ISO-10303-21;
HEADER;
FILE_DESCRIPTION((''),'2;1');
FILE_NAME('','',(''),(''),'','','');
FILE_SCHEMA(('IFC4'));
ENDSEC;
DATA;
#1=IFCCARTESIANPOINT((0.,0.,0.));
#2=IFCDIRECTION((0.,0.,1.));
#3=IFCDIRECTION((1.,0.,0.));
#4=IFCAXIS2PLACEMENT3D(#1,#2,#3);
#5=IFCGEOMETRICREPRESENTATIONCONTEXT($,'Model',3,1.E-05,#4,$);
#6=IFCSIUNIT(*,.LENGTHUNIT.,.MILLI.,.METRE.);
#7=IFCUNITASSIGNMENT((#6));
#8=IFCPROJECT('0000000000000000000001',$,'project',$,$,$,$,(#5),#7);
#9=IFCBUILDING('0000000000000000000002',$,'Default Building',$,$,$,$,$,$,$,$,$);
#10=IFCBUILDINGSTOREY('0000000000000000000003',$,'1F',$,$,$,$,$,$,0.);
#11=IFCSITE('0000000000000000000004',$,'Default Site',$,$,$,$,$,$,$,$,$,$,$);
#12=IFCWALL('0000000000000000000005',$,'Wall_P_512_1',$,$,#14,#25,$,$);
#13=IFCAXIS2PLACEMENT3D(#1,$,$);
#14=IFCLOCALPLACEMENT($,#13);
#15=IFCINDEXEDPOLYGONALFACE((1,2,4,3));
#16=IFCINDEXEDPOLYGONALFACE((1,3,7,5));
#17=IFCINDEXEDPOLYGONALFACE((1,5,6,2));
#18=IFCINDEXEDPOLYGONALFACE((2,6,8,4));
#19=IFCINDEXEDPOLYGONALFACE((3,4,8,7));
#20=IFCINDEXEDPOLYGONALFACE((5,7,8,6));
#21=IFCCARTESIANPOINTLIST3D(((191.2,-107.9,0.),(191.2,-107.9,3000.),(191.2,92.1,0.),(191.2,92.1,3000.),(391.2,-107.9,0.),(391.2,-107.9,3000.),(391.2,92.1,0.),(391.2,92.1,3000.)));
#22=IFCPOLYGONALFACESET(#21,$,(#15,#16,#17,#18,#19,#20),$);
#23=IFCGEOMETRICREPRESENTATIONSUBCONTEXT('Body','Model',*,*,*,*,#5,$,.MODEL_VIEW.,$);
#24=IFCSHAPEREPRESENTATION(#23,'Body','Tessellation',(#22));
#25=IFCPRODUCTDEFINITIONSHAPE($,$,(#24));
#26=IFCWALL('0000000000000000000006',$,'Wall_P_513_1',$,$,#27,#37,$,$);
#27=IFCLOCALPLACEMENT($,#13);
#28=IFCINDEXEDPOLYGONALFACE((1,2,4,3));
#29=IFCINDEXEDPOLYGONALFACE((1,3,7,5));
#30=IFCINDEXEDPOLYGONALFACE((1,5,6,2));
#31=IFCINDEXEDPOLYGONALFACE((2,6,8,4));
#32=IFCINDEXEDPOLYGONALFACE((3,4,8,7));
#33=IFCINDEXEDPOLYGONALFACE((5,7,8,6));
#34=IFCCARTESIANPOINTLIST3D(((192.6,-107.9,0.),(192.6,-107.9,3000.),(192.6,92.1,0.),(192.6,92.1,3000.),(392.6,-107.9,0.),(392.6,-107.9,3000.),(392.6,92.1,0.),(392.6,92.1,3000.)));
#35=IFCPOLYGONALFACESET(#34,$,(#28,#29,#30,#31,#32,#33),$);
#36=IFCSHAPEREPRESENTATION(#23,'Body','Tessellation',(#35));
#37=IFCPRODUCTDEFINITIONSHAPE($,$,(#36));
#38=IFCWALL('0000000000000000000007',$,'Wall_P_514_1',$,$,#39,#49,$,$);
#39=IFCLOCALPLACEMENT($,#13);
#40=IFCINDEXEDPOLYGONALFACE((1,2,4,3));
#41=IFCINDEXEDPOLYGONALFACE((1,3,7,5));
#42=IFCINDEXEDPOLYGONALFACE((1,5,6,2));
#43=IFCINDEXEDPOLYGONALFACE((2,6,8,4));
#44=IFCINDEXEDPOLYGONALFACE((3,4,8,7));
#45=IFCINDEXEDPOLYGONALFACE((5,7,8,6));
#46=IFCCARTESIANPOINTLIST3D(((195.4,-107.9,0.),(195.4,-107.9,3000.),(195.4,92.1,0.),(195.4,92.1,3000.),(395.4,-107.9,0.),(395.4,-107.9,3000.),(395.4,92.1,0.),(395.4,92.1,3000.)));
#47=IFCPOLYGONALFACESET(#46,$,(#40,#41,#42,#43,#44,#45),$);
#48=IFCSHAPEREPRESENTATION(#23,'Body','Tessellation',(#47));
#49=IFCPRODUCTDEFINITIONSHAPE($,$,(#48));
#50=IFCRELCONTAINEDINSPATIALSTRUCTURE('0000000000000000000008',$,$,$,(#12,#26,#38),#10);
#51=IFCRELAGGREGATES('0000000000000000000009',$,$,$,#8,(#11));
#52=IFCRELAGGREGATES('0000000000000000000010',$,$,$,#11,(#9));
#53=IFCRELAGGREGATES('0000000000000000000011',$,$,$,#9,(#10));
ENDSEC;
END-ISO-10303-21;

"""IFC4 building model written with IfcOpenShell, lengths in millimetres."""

from ifc_helpers import new_model, si_unit, frame, origin_with_axes, place, context, subcontext, project, spatial, indexed_curve, outline, extrude, element, save


model = new_model("IFC4")

# Units and contexts
model_context = context("Model", 3, precision=1e-05, world=origin_with_axes())
body_context = subcontext(model_context, "Body", "Model", "MODEL_VIEW")
ifc_project = project(units=[si_unit("LENGTHUNIT", "METRE", prefix="MILLI")], contexts=[model_context])

# Site, building, storey
site = spatial("IfcSite", under=ifc_project, Name="Default Site")
building = spatial("IfcBuilding", under=site, Name="Default Building")
storey = spatial("IfcBuildingStorey", under=building, Name="1F", Elevation=0.0)

# Walls
wall_1_placement = place(None, frame((191.2, 92.1, 0.0), z_axis=(0.0, 0.0, 1.0), x_axis=(0.0, -1.0, 0.0)))
element("IfcWall", 1, at=wall_1_placement, inside=storey, Name="Wall_P_512_1", context=body_context, shape_type="SweptSolid", body=[
    extrude(outline(indexed_curve([(0.0, 0.0), (0.0, 200.0), (200.0, 200.0), (200.0, 0.0), (0.0, 0.0)], self_intersect=False)), origin_with_axes(), (0.0, 0.0, 1.0), 3000.0),
])
wall_2_placement = place(None, frame((192.6, 92.1, 0.0), z_axis=(0.0, 0.0, 1.0), x_axis=(0.0, -1.0, 0.0)))
element("IfcWall", 2, at=wall_2_placement, inside=storey, Name="Wall_P_513_1", context=body_context, shape_type="SweptSolid", body=[
    extrude(outline(indexed_curve([(0.0, 0.0), (0.0, 200.0), (200.0, 200.0), (200.0, 0.0), (0.0, 0.0)], self_intersect=False)), origin_with_axes(), (0.0, 0.0, 1.0), 3000.0),
])
wall_3_placement = place(None, frame((195.4, 92.1, 0.0), z_axis=(0.0, 0.0, 1.0), x_axis=(0.0, -1.0, 0.0)))
element("IfcWall", 3, at=wall_3_placement, inside=storey, Name="Wall_P_514_1", context=body_context, shape_type="SweptSolid", body=[
    extrude(outline(indexed_curve([(0.0, 0.0), (0.0, 200.0), (200.0, 200.0), (200.0, 0.0), (0.0, 0.0)], self_intersect=False)), origin_with_axes(), (0.0, 0.0, 1.0), 3000.0),
])

save(model, "model.ifc")
